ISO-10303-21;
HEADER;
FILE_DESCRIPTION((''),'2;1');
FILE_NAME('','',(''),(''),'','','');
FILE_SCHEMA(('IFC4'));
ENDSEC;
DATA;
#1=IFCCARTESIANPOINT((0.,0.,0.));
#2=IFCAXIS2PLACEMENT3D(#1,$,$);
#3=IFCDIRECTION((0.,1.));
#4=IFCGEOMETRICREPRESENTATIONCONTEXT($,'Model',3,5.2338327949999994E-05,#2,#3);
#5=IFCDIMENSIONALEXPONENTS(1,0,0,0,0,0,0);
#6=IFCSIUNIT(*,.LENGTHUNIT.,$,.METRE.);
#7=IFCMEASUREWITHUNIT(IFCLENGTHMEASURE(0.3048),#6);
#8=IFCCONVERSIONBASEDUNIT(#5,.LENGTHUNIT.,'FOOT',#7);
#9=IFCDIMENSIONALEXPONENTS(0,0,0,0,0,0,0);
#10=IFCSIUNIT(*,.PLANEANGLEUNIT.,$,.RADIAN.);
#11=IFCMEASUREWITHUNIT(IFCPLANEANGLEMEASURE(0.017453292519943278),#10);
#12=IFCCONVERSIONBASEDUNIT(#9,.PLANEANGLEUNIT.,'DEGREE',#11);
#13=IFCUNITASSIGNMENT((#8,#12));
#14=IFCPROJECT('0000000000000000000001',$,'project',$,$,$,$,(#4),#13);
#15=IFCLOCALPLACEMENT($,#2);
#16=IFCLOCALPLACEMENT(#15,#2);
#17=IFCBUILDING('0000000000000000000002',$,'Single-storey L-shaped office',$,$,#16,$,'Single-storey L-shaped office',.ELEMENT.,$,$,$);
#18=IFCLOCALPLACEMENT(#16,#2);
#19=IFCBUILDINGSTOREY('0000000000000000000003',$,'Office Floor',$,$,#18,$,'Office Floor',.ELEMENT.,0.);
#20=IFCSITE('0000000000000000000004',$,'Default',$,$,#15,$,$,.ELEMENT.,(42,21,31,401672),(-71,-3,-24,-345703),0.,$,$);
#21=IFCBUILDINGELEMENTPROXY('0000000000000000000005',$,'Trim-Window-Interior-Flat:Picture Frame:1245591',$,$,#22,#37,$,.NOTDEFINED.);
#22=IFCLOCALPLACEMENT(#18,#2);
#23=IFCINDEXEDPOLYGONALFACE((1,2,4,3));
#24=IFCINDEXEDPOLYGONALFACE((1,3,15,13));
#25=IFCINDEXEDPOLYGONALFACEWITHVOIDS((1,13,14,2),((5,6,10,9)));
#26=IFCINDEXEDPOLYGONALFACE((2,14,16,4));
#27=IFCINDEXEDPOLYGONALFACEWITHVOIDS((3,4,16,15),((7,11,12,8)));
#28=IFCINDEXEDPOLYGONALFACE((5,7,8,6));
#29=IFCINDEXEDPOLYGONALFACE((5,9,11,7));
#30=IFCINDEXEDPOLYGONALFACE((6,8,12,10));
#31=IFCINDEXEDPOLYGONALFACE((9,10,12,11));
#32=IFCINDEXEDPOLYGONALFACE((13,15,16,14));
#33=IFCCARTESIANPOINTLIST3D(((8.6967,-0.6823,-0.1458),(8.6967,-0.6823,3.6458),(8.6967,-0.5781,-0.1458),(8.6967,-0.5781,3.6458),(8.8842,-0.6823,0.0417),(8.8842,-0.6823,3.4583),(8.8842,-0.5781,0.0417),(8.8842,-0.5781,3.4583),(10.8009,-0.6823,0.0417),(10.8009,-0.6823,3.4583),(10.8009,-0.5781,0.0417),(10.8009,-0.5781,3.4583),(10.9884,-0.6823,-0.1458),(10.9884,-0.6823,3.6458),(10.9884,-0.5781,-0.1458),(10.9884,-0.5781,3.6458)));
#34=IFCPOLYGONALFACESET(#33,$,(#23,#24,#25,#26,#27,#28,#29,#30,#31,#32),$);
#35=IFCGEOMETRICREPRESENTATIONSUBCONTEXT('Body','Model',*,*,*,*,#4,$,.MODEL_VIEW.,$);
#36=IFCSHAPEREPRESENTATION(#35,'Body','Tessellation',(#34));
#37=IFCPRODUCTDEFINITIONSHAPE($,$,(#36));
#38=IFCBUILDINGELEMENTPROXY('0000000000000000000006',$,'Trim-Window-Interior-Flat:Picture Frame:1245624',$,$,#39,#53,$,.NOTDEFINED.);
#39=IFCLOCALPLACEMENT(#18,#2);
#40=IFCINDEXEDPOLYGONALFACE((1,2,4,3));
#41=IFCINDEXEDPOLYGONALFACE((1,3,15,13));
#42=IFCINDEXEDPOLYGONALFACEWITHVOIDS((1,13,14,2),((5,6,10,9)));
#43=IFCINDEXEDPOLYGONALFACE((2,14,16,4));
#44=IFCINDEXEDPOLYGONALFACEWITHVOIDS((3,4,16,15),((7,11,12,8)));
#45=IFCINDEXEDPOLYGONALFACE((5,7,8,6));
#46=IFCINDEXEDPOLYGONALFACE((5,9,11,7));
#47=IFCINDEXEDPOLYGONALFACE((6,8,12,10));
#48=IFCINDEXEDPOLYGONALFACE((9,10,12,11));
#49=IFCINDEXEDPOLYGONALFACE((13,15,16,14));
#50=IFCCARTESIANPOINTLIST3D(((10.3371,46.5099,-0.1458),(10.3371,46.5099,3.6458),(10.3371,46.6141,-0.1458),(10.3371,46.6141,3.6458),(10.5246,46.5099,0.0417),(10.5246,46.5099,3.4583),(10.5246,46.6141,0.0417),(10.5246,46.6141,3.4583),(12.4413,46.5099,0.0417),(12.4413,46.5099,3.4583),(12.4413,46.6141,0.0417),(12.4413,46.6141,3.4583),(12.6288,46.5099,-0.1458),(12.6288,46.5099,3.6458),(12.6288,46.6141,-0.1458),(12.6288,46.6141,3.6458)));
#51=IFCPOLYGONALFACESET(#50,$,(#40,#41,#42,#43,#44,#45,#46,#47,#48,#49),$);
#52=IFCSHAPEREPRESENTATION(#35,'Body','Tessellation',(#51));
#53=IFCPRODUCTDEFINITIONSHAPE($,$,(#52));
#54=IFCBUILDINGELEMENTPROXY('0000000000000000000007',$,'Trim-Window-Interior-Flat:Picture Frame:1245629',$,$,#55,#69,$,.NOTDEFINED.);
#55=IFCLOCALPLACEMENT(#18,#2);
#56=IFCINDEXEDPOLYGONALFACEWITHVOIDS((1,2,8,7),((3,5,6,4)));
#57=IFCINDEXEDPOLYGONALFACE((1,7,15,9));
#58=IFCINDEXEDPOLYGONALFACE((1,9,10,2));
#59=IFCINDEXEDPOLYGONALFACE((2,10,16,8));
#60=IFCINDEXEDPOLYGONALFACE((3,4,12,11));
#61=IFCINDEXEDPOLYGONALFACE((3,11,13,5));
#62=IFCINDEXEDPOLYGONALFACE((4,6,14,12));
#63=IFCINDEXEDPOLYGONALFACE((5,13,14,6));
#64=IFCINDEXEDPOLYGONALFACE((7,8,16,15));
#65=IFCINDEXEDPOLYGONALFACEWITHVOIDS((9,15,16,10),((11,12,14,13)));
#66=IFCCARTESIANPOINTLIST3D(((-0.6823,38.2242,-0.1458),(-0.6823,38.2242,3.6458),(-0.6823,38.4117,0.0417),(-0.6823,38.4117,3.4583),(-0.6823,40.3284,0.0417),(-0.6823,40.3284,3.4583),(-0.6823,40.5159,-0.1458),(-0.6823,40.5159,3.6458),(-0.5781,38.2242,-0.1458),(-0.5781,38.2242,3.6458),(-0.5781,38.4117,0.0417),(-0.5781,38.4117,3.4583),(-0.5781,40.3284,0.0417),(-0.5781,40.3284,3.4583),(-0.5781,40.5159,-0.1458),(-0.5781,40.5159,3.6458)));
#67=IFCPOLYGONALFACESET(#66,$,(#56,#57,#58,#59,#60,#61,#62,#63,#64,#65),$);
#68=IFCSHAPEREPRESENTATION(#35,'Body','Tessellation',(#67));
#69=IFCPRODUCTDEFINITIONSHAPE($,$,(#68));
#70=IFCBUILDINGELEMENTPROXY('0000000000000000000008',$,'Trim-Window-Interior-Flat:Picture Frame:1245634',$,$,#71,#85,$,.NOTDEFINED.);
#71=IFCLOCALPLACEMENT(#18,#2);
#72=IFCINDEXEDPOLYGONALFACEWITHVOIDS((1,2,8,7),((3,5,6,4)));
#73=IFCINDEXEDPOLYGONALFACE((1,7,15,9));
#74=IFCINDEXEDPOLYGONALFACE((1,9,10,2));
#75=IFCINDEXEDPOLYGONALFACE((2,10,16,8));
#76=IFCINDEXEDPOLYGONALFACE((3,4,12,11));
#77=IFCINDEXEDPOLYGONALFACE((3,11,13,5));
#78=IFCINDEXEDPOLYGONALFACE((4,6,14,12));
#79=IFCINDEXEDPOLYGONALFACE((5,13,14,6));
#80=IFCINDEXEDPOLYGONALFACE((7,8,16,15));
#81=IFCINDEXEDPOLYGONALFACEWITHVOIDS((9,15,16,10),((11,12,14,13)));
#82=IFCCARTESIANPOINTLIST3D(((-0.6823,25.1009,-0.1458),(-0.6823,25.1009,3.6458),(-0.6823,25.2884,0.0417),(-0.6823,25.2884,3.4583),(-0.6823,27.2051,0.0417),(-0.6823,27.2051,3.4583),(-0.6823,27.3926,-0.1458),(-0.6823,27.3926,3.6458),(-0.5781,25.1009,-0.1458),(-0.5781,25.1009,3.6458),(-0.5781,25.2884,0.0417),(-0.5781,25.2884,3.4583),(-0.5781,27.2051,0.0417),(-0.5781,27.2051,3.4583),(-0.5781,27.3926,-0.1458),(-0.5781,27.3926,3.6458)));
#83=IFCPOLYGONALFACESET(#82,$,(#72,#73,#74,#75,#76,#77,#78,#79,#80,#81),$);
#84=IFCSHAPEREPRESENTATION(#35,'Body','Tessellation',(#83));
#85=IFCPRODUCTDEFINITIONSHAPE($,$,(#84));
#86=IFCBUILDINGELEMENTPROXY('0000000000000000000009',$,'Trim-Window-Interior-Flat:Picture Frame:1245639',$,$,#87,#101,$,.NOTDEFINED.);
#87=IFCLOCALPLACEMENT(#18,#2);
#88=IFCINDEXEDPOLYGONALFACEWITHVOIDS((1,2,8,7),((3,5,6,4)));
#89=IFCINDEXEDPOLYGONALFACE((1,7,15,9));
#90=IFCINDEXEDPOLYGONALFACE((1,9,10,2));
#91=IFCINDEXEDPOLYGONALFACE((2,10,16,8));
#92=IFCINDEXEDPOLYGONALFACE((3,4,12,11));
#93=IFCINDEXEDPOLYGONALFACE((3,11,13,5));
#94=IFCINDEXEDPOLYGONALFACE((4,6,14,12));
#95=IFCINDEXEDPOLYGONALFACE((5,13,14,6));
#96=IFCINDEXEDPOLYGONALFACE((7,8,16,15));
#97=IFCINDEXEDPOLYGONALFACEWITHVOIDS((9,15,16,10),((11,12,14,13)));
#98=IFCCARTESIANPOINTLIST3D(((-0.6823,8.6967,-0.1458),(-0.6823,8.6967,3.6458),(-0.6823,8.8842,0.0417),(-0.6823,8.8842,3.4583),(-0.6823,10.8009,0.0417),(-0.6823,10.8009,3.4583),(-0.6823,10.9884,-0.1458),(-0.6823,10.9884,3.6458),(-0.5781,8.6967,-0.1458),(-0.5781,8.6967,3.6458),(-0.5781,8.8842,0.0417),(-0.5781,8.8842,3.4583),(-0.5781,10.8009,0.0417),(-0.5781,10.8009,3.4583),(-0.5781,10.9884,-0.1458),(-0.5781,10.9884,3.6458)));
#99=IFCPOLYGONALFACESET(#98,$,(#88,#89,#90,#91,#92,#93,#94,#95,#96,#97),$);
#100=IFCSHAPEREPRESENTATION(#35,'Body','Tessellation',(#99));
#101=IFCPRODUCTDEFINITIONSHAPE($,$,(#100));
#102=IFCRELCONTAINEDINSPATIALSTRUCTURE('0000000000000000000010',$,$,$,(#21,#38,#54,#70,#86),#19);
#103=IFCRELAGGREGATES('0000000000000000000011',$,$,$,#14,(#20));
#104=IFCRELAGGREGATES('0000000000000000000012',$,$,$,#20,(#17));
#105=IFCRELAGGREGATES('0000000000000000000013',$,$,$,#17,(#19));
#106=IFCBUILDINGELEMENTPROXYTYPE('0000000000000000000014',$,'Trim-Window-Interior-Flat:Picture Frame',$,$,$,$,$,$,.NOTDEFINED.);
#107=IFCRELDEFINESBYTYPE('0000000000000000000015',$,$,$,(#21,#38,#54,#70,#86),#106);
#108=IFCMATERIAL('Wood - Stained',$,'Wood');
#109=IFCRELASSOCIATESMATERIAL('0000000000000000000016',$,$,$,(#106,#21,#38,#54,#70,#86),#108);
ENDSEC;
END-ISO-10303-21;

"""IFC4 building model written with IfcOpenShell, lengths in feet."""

from ifc_helpers import new_model, entity, si_unit, converted_unit, direction, frame, origin, place, context, subcontext, project, spatial, indexed_curve, outline, extrude, source, transform, mapped, material, type_object, type_shapes, element, save


model = new_model("IFC4")

# Units and contexts
model_context = context("Model", 3, precision=5.2338327949999994e-05, world=origin(), true_north=direction((0.0, 1.0)))
body_context = subcontext(model_context, "Body", "Model", "MODEL_VIEW")
ifc_project = project(units=[converted_unit("LENGTHUNIT", "FOOT", entity("IfcLengthMeasure", 0.3048), si_unit("LENGTHUNIT", "METRE"), dimensions=[1, 0, 0, 0, 0, 0, 0]), converted_unit("PLANEANGLEUNIT", "DEGREE", entity("IfcPlaneAngleMeasure", 0.017453292519943278), si_unit("PLANEANGLEUNIT", "RADIAN"), dimensions=[0, 0, 0, 0, 0, 0, 0])], contexts=[model_context])

# Site, building, storey
site_placement = place(None, origin())
site = spatial("IfcSite", under=ifc_project, at=site_placement, Name="Default", CompositionType="ELEMENT", RefLatitude=(42, 21, 31, 401672), RefLongitude=(-71, -3, -24, -345703), RefElevation=0.0)
building_placement = place(site_placement, origin())
building = spatial("IfcBuilding", under=site, at=building_placement, Name="Single-storey L-shaped office", LongName="Single-storey L-shaped office", CompositionType="ELEMENT")
storey_placement = place(building_placement, origin())
storey = spatial("IfcBuildingStorey", under=building, at=storey_placement, Name="Office Floor", LongName="Office Floor", CompositionType="ELEMENT", Elevation=0.0)

# Shared definitions
ifc_material_1 = material(Name="Wood - Stained", Category="Wood")

# Building element proxies
building_element_proxy_type_1 = type_object("IfcBuildingElementProxyType", Name="Trim-Window-Interior-Flat:Picture Frame", PredefinedType="NOTDEFINED", material=ifc_material_1)
shared_shape_1 = source(origin(), body_context, "Body", "SweptSolid", [
    extrude(outline(indexed_curve([(-1.1458, -1.8958), (1.1458, -1.8958), (1.1458, 1.8958), (-1.1458, 1.8958), (-1.1458, -1.8958)], self_intersect=False), holes=[indexed_curve([(-0.9583, -1.7083), (-0.9583, 1.7083), (0.9583, 1.7083), (0.9583, -1.7083), (-0.9583, -1.7083)], self_intersect=False)]), frame((0.0, -1.75, 0.0), z_axis=(0.0, 0.0, 1.0), x_axis=(-1.0, 0.0, 0.0)), (0.0, 0.0, 1.0), 0.1042),
])
type_shapes(building_element_proxy_type_1, [shared_shape_1])
for number, where, z_axis, x_axis, name in (
    (1, (9.8425, -0.5781, 3.5), (0.0, -1.0, 0.0), (1.0, 0.0, 0.0), "Trim-Window-Interior-Flat:Picture Frame:1245591"),
    (2, (11.4829, 46.5099, 3.5), (0.0, 1.0, 0.0), (-1.0, 0.0, 0.0), "Trim-Window-Interior-Flat:Picture Frame:1245624"),
    (3, (-0.5781, 39.3701, 3.5), (-1.0, 0.0, 0.0), (0.0, -1.0, 0.0), "Trim-Window-Interior-Flat:Picture Frame:1245629"),
    (4, (-0.5781, 26.2467, 3.5), (-1.0, 0.0, 0.0), (0.0, -1.0, 0.0), "Trim-Window-Interior-Flat:Picture Frame:1245634"),
    (5, (-0.5781, 9.8425, 3.5), (-1.0, 0.0, 0.0), (0.0, -1.0, 0.0), "Trim-Window-Interior-Flat:Picture Frame:1245639"),
):
    element("IfcBuildingElementProxy", number, at=place(storey_placement, frame(where, z_axis=z_axis, x_axis=x_axis)), inside=storey, type_object=building_element_proxy_type_1, material=ifc_material_1, Name=name, PredefinedType="NOTDEFINED", context=body_context, shape_type="MappedRepresentation", body=[
        mapped(shared_shape_1, transform((0.0, 0.0, 0.0), scale=1.0)),
    ])

save(model, "model.ifc")
